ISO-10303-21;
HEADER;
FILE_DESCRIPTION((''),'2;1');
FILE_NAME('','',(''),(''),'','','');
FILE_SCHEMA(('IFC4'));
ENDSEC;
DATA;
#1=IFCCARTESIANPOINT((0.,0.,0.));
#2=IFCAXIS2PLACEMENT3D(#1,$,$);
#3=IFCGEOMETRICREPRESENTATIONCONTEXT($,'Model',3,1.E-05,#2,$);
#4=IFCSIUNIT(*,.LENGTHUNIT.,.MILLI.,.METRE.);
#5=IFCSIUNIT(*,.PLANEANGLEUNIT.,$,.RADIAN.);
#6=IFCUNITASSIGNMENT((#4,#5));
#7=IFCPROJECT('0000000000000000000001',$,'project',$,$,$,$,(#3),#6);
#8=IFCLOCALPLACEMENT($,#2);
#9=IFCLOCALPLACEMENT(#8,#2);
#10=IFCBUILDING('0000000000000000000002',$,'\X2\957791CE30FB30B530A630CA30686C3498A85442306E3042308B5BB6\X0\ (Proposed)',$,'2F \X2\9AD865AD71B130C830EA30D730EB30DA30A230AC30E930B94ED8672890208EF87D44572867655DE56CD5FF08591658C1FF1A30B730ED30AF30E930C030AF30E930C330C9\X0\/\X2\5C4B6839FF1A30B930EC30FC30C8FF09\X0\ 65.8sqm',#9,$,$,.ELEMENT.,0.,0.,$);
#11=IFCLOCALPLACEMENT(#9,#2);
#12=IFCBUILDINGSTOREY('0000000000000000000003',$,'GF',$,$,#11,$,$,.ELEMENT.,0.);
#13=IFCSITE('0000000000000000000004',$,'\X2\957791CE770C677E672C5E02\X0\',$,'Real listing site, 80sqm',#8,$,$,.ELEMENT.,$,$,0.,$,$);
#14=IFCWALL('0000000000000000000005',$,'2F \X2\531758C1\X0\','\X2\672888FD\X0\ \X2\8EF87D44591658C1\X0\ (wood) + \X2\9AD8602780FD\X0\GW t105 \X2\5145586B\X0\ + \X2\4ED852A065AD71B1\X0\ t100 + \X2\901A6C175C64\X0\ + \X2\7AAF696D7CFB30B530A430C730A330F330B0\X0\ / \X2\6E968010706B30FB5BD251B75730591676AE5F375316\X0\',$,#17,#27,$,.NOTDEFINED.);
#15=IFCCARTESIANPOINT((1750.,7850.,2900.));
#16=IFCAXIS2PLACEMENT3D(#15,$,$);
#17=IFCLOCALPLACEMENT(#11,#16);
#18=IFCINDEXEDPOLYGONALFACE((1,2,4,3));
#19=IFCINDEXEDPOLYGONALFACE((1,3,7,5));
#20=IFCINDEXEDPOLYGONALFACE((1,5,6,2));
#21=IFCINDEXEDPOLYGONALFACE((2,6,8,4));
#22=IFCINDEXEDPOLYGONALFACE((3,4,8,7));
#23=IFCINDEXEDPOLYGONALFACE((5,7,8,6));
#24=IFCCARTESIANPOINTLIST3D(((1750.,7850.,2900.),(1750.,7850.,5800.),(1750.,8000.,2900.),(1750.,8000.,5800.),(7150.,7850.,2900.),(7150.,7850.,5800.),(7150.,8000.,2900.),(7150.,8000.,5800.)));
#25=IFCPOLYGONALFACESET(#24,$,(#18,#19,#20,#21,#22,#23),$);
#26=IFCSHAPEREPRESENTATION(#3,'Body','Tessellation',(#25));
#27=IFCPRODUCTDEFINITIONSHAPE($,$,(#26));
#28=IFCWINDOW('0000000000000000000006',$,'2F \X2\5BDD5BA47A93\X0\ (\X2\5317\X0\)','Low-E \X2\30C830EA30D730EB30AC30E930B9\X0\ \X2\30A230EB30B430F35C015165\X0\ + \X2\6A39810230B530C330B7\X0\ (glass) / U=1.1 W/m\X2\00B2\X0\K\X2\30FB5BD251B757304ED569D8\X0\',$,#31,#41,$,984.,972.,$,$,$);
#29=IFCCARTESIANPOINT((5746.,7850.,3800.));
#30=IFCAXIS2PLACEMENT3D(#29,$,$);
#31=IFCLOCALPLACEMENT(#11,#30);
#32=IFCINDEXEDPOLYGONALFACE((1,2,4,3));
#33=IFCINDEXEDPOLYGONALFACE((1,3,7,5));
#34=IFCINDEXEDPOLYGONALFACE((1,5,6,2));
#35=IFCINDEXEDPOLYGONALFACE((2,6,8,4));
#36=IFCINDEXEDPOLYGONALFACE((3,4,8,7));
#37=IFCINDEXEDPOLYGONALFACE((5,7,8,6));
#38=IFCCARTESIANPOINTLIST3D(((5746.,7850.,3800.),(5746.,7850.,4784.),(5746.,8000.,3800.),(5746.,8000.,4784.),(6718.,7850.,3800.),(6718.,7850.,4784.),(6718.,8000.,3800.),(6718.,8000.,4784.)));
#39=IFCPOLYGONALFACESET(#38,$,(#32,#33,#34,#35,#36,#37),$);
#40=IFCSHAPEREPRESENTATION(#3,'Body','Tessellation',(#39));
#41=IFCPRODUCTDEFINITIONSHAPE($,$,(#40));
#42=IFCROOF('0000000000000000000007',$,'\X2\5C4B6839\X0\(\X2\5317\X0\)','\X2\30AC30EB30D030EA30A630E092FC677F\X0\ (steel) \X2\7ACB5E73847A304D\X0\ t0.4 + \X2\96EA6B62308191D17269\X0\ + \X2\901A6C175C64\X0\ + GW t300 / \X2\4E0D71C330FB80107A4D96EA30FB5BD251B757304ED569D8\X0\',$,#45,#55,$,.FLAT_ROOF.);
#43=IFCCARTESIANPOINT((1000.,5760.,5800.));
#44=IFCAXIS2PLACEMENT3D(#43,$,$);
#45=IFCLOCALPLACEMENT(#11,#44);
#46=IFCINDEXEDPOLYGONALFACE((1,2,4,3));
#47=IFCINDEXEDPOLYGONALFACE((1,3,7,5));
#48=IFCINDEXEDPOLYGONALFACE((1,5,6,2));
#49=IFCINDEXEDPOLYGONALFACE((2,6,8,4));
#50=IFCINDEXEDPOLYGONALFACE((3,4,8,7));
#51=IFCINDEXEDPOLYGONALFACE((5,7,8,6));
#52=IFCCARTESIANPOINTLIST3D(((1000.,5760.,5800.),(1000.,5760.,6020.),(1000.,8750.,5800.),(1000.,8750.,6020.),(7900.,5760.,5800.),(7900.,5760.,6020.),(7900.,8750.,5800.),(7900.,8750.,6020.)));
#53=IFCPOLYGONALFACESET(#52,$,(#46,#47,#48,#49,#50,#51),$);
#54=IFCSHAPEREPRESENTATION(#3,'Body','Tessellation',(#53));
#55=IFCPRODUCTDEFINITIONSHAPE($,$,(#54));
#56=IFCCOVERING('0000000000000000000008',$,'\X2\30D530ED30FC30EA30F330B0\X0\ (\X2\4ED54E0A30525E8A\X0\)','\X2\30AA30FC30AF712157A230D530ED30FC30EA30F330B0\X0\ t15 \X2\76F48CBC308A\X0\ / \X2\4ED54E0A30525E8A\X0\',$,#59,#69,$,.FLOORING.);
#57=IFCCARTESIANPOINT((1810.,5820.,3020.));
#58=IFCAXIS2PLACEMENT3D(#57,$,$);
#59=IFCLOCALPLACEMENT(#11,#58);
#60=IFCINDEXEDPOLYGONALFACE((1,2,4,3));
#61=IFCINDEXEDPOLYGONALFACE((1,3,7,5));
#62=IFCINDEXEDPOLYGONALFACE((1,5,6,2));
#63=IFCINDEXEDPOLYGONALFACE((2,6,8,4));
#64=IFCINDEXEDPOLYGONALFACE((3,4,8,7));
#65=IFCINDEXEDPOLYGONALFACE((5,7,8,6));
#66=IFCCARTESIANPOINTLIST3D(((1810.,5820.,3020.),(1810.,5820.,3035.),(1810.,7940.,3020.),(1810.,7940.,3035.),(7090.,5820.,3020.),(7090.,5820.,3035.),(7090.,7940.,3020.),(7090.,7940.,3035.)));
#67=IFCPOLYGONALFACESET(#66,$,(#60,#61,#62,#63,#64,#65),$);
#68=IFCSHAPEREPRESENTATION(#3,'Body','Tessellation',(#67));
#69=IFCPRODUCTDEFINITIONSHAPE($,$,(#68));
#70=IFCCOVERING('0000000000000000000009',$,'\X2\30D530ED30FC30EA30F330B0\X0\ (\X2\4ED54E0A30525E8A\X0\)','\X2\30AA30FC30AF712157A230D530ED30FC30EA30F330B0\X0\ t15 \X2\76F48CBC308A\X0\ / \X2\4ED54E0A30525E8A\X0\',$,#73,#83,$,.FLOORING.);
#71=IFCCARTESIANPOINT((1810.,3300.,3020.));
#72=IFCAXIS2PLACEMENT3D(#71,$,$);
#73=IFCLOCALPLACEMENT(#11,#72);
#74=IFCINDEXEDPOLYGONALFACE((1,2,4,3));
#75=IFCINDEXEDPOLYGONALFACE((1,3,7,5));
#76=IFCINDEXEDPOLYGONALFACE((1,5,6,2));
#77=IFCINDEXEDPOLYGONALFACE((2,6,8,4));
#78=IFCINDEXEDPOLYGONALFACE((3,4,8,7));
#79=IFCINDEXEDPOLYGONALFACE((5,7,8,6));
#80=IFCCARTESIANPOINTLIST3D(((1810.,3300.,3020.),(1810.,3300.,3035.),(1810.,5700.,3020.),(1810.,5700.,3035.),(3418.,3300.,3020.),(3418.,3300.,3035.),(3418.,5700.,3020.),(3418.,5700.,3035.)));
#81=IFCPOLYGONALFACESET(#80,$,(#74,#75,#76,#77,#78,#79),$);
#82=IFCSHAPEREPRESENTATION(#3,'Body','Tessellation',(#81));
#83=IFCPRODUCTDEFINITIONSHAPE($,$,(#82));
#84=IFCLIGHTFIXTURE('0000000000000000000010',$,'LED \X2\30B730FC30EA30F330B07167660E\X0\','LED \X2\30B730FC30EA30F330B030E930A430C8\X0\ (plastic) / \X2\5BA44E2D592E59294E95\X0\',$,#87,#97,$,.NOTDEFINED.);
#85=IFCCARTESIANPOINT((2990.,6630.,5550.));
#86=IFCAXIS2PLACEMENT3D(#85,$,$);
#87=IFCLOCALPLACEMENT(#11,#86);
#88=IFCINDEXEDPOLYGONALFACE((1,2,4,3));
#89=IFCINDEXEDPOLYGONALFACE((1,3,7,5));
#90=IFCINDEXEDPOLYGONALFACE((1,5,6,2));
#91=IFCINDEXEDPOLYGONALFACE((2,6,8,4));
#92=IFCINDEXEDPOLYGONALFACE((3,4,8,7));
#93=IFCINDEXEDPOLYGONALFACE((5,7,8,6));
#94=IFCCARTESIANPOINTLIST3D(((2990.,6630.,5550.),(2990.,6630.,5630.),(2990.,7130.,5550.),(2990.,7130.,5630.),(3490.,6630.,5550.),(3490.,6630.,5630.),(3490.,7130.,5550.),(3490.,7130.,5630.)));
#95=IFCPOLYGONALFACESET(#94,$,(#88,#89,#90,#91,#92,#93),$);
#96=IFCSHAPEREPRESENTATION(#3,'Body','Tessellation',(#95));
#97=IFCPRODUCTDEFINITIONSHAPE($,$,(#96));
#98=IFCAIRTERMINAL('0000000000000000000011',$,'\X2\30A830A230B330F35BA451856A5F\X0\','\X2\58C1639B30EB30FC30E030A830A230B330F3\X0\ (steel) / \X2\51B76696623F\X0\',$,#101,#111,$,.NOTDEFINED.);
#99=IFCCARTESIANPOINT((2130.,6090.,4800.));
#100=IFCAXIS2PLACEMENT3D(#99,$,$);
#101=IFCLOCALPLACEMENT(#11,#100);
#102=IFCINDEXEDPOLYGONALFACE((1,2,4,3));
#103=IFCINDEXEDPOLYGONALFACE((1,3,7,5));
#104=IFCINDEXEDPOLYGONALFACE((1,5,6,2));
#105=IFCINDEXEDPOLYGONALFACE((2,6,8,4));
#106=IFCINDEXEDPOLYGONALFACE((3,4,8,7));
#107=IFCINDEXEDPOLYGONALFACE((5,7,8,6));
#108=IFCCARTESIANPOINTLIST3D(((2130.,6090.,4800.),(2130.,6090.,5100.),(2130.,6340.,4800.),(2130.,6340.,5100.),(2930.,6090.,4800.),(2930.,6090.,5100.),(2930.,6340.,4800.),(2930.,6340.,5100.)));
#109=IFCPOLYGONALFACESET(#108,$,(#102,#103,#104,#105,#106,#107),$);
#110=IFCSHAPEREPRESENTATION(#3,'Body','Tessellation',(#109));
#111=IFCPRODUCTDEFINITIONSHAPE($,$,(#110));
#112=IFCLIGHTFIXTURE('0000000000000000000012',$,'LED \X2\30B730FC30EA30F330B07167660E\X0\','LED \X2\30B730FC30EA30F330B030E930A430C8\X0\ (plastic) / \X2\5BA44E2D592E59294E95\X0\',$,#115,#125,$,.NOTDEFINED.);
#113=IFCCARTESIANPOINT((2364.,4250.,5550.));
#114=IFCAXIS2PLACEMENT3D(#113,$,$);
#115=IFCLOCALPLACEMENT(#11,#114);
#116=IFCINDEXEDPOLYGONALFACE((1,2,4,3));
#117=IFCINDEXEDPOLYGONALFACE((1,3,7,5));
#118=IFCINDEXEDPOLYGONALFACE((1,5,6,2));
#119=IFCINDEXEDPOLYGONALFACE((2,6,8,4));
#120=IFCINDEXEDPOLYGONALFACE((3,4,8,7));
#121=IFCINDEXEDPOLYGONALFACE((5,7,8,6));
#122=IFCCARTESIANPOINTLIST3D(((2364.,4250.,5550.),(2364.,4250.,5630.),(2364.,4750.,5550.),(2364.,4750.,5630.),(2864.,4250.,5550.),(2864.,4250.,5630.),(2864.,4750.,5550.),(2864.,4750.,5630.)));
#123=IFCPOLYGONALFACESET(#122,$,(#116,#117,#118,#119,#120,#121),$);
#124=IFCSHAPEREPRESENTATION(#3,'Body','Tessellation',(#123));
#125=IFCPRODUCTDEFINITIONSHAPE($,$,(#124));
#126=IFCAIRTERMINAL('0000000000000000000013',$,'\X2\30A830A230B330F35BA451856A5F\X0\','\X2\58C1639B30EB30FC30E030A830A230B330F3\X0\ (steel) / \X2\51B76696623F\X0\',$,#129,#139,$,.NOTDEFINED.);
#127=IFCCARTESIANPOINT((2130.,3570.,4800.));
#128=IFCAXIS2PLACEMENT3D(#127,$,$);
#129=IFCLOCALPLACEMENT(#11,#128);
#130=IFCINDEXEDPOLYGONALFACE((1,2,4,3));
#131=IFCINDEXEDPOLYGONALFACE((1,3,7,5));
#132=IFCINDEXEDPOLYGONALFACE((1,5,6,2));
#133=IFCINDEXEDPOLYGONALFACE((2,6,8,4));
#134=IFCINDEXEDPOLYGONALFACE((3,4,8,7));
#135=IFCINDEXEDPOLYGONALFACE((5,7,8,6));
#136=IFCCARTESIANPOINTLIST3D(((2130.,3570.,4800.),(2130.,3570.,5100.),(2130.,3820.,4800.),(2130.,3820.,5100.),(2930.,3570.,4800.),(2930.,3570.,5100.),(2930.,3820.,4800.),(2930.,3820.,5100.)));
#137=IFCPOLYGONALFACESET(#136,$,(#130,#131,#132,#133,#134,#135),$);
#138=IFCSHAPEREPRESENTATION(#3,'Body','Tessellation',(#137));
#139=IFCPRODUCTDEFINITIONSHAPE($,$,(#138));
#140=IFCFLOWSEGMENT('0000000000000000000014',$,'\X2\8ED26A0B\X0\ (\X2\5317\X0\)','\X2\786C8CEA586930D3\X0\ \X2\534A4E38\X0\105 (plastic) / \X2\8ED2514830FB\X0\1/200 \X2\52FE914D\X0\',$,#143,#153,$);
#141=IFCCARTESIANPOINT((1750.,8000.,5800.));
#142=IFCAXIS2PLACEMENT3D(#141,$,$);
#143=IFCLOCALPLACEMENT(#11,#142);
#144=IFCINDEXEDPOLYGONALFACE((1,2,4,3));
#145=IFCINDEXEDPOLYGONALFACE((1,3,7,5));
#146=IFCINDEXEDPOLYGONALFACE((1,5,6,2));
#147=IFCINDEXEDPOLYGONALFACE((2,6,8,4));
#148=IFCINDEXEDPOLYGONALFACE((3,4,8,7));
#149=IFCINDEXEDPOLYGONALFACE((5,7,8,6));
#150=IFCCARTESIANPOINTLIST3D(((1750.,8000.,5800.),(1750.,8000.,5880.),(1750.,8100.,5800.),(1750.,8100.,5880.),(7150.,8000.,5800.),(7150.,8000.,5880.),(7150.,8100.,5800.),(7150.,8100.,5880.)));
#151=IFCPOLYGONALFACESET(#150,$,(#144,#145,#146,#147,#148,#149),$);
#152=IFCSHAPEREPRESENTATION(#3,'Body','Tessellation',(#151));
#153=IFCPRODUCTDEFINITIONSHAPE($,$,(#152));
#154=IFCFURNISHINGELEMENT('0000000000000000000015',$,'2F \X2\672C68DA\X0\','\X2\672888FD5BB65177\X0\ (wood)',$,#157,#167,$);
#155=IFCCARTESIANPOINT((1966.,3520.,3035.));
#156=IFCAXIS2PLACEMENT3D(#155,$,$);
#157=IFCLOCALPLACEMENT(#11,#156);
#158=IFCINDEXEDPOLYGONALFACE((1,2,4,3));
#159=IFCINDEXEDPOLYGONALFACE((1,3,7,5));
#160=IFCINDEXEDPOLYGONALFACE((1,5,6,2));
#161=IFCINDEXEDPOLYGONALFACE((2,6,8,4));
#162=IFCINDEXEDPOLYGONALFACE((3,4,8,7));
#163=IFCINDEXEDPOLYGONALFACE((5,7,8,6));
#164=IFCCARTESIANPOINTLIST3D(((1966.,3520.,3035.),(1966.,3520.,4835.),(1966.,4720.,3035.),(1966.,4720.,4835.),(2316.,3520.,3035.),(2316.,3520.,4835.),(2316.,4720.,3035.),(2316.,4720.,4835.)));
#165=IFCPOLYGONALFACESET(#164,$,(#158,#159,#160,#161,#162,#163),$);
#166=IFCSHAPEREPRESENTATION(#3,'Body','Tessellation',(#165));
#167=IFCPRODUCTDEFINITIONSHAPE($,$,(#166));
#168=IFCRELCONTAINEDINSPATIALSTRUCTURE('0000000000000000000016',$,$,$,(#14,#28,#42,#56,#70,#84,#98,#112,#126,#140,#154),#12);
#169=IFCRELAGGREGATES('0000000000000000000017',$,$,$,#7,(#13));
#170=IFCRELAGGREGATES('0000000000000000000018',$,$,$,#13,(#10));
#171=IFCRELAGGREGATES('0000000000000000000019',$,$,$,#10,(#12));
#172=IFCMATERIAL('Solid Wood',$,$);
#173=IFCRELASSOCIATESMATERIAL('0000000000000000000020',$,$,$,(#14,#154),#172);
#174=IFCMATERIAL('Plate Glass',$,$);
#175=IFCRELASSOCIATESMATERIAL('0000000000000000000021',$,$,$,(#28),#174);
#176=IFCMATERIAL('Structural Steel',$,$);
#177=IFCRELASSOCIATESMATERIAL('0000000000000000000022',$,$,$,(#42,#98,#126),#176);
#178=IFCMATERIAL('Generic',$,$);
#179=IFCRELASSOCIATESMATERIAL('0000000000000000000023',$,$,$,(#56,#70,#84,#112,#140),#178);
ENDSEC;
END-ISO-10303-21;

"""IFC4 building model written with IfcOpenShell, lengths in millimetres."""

from ifc_helpers import new_model, si_unit, frame, frame_2d, origin, place, context, project, spatial, rectangle, extrude, material, element, fill, save


model = new_model("IFC4")

# Units and contexts
model_context = context("Model", 3, precision=1e-05, world=origin())
ifc_project = project(units=[si_unit("LENGTHUNIT", "METRE", prefix="MILLI"), si_unit("PLANEANGLEUNIT", "RADIAN")], contexts=[model_context])

# Site, building, storey
site_placement = place(None, origin())
site = spatial("IfcSite", under=ifc_project, at=site_placement, Name="長野県松本市", ObjectType="Real listing site, 80sqm", CompositionType="ELEMENT", RefElevation=0.0)
building_placement = place(site_placement, origin())
building = spatial("IfcBuilding", under=site, at=building_placement, Name="長野・サウナと水風呂のある家 (Proposed)", ObjectType="2F 高断熱トリプルペアガラス付木造軸組在来工法（外壁：シロクラダクラッド/屋根：スレート） 65.8sqm", CompositionType="ELEMENT", ElevationOfRefHeight=0.0, ElevationOfTerrain=0.0)
storey_placement = place(building_placement, origin())
storey = spatial("IfcBuildingStorey", under=building, at=storey_placement, Name="GF", CompositionType="ELEMENT", Elevation=0.0)

# Shared definitions
ifc_material_1 = material(Name="Solid Wood")

# Wall, opening, window
wall_placement = place(storey_placement, frame((1750.0, 7850.0, 2900.0)))
wall = element("IfcWall", 1, at=wall_placement, inside=storey, material=ifc_material_1, Name="2F 北壁", Description="木製 軸組外壁 (wood) + 高性能GW t105 充填 + 付加断熱 t100 + 通気層 + 窯業系サイディング / 準耐火・寒冷地外皮強化", PredefinedType="NOTDEFINED", context=model_context, shape_type="SweptSolid", body=[
    extrude(rectangle(XDim=5400.0, YDim=150.0, at=frame_2d((2700.0, 75.0))), frame((1750.0, 7850.0, 2900.0)), (0.0, 0.0, 1.0), 2900.0),
])
opening_placement = place(storey_placement, frame((5746.0, 7850.0, 3800.0)))
opening = element("IfcOpeningElement", 2, at=opening_placement, cuts=wall, PredefinedType="NOTDEFINED", context=model_context, shape_type="SweptSolid", body=[
    extrude(rectangle(XDim=972.0, YDim=150.0, at=frame_2d((486.0, 75.0))), frame((5746.0, 7850.0, 3800.0)), (0.0, 0.0, 1.0), 984.0),
])
ifc_material_2 = material(Name="Plate Glass")
window_placement = place(storey_placement, frame((5746.0, 7850.0, 3800.0)))
window = element("IfcWindow", 3, at=window_placement, inside=storey, material=ifc_material_2, Name="2F 寝室窓 (北)", Description="Low-E トリプルガラス アルゴン封入 + 樹脂サッシ (glass) / U=1.1 W/m²K・寒冷地仕様", OverallHeight=984.0, OverallWidth=972.0, context=model_context, shape_type="SweptSolid", body=[
    extrude(rectangle(XDim=972.0, YDim=150.0, at=frame_2d((486.0, 75.0))), frame((5746.0, 7850.0, 3800.0)), (0.0, 0.0, 1.0), 984.0),
])
fill(opening, window)

# Roof
ifc_material_3 = material(Name="Structural Steel")
for number, where, name in (
    (4, (1000.0, 5760.0, 5800.0), "屋根(北)"),
):
    element("IfcRoof", number, at=place(storey_placement, frame(where)), inside=storey, material=ifc_material_3, Name=name, Description="ガルバリウム鋼板 (steel) 立平葺き t0.4 + 雪止め金物 + 通気層 + GW t300 / 不燃・耐積雪・寒冷地仕様", PredefinedType="FLAT_ROOF", context=model_context, shape_type="SweptSolid", body=[
        extrude(rectangle(XDim=6900.0, YDim=2990.0, at=frame_2d((3450.0, 1495.0))), frame((1000.0, 5760.0, 5800.0)), (0.0, 0.0, 1.0), 220.0),
    ])

# Coverings
ifc_material_4 = material(Name="Generic")
covering_1_placement = place(storey_placement, frame((1810.0, 5820.0, 3020.0)))
element("IfcCovering", 5, at=covering_1_placement, inside=storey, material=ifc_material_4, Name="フローリング (仕上げ床)", Description="オーク無垢フローリング t15 直貼り / 仕上げ床", PredefinedType="FLOORING", context=model_context, shape_type="SweptSolid", body=[
    extrude(rectangle(XDim=5280.0, YDim=2120.0, at=frame_2d((2640.0, 1060.0))), frame((1810.0, 5820.0, 3020.0)), (0.0, 0.0, 1.0), 15.0),
])
covering_2_placement = place(storey_placement, frame((1810.0, 3300.0, 3020.0)))
element("IfcCovering", 6, at=covering_2_placement, inside=storey, material=ifc_material_4, Name="フローリング (仕上げ床)", Description="オーク無垢フローリング t15 直貼り / 仕上げ床", PredefinedType="FLOORING", context=model_context, shape_type="SweptSolid", body=[
    extrude(rectangle(XDim=1608.0, YDim=2400.0, at=frame_2d((804.0, 1200.0))), frame((1810.0, 3300.0, 3020.0)), (0.0, 0.0, 1.0), 15.0),
])

# Light fixture
light_fixture_1_placement = place(storey_placement, frame((2990.0, 6630.0, 5550.0)))
element("IfcLightFixture", 7, at=light_fixture_1_placement, inside=storey, material=ifc_material_4, Name="LED シーリング照明", Description="LED シーリングライト (plastic) / 室中央天井", PredefinedType="NOTDEFINED", context=model_context, shape_type="SweptSolid", body=[
    extrude(rectangle(XDim=500.0, YDim=500.0, at=frame_2d((250.0, 250.0))), frame((2990.0, 6630.0, 5550.0)), (0.0, 0.0, 1.0), 80.0),
])

# Air terminal
air_terminal_1_placement = place(storey_placement, frame((2130.0, 6090.0, 4800.0)))
element("IfcAirTerminal", 8, at=air_terminal_1_placement, inside=storey, material=ifc_material_3, Name="エアコン室内機", Description="壁掛ルームエアコン (steel) / 冷暖房", PredefinedType="NOTDEFINED", context=model_context, shape_type="SweptSolid", body=[
    extrude(rectangle(XDim=800.0, YDim=250.0, at=frame_2d((400.0, 125.0))), frame((2130.0, 6090.0, 4800.0)), (0.0, 0.0, 1.0), 300.0),
])

# Light fixture
light_fixture_2_placement = place(storey_placement, frame((2364.0, 4250.0, 5550.0)))
element("IfcLightFixture", 9, at=light_fixture_2_placement, inside=storey, material=ifc_material_4, Name="LED シーリング照明", Description="LED シーリングライト (plastic) / 室中央天井", PredefinedType="NOTDEFINED", context=model_context, shape_type="SweptSolid", body=[
    extrude(rectangle(XDim=500.0, YDim=500.0, at=frame_2d((250.0, 250.0))), frame((2364.0, 4250.0, 5550.0)), (0.0, 0.0, 1.0), 80.0),
])

# Air terminal
air_terminal_2_placement = place(storey_placement, frame((2130.0, 3570.0, 4800.0)))
element("IfcAirTerminal", 10, at=air_terminal_2_placement, inside=storey, material=ifc_material_3, Name="エアコン室内機", Description="壁掛ルームエアコン (steel) / 冷暖房", PredefinedType="NOTDEFINED", context=model_context, shape_type="SweptSolid", body=[
    extrude(rectangle(XDim=800.0, YDim=250.0, at=frame_2d((400.0, 125.0))), frame((2130.0, 3570.0, 4800.0)), (0.0, 0.0, 1.0), 300.0),
])

# Flow segment
flow_segment_placement = place(storey_placement, frame((1750.0, 8000.0, 5800.0)))
element("IfcFlowSegment", 11, at=flow_segment_placement, inside=storey, material=ifc_material_4, Name="軒樋 (北)", Description="硬質塩ビ 半丸105 (plastic) / 軒先・1/200 勾配", context=model_context, shape_type="SweptSolid", body=[
    extrude(rectangle(XDim=5400.0, YDim=100.0, at=frame_2d((2700.0, 50.0))), frame((1750.0, 8000.0, 5800.0)), (0.0, 0.0, 1.0), 80.0),
])

# Furnishing element
furnishing_placement = place(storey_placement, frame((1966.0, 3520.0, 3035.0)))
element("IfcFurnishingElement", 12, at=furnishing_placement, inside=storey, material=ifc_material_1, Name="2F 本棚", Description="木製家具 (wood)", context=model_context, shape_type="SweptSolid", body=[
    extrude(rectangle(XDim=350.0, YDim=1200.0, at=frame_2d((175.0, 600.0))), frame((1966.0, 3520.0, 3035.0)), (0.0, 0.0, 1.0), 1800.0),
])

save(model, "model.ifc")
